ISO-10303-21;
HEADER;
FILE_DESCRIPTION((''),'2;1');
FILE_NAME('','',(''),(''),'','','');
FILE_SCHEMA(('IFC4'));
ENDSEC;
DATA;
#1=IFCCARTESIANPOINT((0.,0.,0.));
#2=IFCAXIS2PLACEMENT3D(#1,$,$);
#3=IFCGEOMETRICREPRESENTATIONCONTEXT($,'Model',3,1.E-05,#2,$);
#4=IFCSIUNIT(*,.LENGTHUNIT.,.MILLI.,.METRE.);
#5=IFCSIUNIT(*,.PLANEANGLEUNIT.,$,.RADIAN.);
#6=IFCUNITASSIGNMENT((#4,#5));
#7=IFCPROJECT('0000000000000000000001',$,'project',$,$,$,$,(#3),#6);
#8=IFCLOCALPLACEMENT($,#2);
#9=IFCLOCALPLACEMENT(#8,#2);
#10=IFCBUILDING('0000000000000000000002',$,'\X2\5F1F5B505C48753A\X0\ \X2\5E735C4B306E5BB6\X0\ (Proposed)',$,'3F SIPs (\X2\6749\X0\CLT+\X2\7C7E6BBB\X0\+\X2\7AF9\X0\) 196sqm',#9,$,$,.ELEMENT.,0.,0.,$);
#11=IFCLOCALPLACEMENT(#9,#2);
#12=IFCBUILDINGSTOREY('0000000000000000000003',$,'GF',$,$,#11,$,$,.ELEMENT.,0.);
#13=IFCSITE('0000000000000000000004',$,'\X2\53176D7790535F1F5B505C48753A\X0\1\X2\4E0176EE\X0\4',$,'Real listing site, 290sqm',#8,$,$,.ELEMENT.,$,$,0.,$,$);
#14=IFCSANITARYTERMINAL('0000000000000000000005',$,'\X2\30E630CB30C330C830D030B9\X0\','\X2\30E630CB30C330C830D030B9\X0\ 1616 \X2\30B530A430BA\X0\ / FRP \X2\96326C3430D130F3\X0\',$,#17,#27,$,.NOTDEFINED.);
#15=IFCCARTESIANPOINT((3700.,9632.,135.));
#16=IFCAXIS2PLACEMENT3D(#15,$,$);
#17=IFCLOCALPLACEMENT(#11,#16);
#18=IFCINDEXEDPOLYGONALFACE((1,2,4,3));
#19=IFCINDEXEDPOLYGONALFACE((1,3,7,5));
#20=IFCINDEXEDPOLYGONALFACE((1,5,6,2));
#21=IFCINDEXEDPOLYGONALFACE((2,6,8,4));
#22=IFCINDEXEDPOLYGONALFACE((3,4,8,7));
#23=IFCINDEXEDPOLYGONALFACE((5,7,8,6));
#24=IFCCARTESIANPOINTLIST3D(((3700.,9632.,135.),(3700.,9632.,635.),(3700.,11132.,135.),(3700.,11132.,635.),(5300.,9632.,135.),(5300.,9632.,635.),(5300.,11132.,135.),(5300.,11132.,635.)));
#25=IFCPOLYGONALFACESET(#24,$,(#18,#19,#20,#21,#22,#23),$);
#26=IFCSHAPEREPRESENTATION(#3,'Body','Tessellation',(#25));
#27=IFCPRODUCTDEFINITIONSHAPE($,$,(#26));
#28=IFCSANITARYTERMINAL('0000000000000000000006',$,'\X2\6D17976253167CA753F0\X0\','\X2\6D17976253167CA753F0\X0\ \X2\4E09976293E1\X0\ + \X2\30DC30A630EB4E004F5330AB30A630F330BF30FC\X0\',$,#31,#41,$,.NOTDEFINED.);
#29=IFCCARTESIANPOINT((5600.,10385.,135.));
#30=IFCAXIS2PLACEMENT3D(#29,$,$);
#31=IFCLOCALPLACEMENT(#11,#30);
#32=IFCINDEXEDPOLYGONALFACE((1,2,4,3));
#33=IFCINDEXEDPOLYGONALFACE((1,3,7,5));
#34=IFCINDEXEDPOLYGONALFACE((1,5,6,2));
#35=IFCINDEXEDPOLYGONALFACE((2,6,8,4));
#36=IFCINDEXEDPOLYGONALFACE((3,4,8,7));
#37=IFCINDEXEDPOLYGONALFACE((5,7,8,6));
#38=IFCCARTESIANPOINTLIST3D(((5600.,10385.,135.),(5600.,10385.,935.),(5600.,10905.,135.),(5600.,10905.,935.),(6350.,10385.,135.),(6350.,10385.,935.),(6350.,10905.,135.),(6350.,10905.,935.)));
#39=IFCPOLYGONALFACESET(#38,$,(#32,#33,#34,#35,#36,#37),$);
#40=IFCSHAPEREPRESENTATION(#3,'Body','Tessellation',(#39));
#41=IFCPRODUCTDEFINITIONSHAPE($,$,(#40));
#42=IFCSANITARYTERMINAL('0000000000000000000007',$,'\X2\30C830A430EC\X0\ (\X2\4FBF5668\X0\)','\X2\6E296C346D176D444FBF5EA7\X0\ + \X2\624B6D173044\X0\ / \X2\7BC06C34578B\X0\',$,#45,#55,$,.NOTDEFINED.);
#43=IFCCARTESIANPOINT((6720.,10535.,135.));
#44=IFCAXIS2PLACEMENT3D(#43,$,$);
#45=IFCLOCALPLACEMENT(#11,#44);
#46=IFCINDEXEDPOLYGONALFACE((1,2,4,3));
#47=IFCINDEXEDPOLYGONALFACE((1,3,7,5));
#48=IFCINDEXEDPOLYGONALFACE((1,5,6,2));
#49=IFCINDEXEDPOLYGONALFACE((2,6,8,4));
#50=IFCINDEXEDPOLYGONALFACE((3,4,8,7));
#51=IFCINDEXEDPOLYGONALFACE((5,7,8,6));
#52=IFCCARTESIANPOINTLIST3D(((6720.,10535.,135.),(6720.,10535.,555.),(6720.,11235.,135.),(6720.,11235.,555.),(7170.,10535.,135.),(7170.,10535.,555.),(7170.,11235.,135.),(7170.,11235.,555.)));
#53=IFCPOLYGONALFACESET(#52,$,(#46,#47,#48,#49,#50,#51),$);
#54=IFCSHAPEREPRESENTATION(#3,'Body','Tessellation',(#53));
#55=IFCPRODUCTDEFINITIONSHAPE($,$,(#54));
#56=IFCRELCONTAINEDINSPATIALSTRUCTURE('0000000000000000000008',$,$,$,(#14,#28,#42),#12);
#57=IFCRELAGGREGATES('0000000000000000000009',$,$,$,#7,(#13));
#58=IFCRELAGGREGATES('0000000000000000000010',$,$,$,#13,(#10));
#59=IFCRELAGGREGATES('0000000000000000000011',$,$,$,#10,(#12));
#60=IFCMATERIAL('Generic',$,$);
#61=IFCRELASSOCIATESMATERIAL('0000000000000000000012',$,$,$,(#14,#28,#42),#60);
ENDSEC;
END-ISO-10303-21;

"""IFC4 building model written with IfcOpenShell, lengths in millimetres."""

from ifc_helpers import new_model, si_unit, frame, frame_2d, origin, place, context, project, spatial, rectangle, extrude, material, element, save


model = new_model("IFC4")

# Units and contexts
model_context = context("Model", 3, precision=1e-05, world=origin())
ifc_project = project(units=[si_unit("LENGTHUNIT", "METRE", prefix="MILLI"), si_unit("PLANEANGLEUNIT", "RADIAN")], contexts=[model_context])

# Site, building, storey
site_placement = place(None, origin())
site = spatial("IfcSite", under=ifc_project, at=site_placement, Name="北海道弟子屈町1丁目4", ObjectType="Real listing site, 290sqm", CompositionType="ELEMENT", RefElevation=0.0)
building_placement = place(site_placement, origin())
building = spatial("IfcBuilding", under=site, at=building_placement, Name="弟子屈町 平屋の家 (Proposed)", ObjectType="3F SIPs (杉CLT+籾殻+竹) 196sqm", CompositionType="ELEMENT", ElevationOfRefHeight=0.0, ElevationOfTerrain=0.0)
storey_placement = place(building_placement, origin())
storey = spatial("IfcBuildingStorey", under=building, at=storey_placement, Name="GF", CompositionType="ELEMENT", Elevation=0.0)

# Shared definitions
ifc_material_1 = material(Name="Generic")

# Sanitary terminals
sanitary_terminal_1_placement = place(storey_placement, frame((3700.0, 9632.0, 135.0)))
element("IfcSanitaryTerminal", 1, at=sanitary_terminal_1_placement, inside=storey, material=ifc_material_1, Name="ユニットバス", Description="ユニットバス 1616 サイズ / FRP 防水パン", PredefinedType="NOTDEFINED", context=model_context, shape_type="SweptSolid", body=[
    extrude(rectangle(XDim=1600.0, YDim=1500.0, at=frame_2d((800.0, 750.0))), frame((3700.0, 9632.0, 135.0)), (0.0, 0.0, 1.0), 500.0),
])
sanitary_terminal_2_placement = place(storey_placement, frame((5600.0, 10385.0, 135.0)))
element("IfcSanitaryTerminal", 2, at=sanitary_terminal_2_placement, inside=storey, material=ifc_material_1, Name="洗面化粧台", Description="洗面化粧台 三面鏡 + ボウル一体カウンター", PredefinedType="NOTDEFINED", context=model_context, shape_type="SweptSolid", body=[
    extrude(rectangle(XDim=750.0, YDim=520.0, at=frame_2d((375.0, 260.0))), frame((5600.0, 10385.0, 135.0)), (0.0, 0.0, 1.0), 800.0),
])
sanitary_terminal_3_placement = place(storey_placement, frame((6720.0, 10535.0, 135.0)))
element("IfcSanitaryTerminal", 3, at=sanitary_terminal_3_placement, inside=storey, material=ifc_material_1, Name="トイレ (便器)", Description="温水洗浄便座 + 手洗い / 節水型", PredefinedType="NOTDEFINED", context=model_context, shape_type="SweptSolid", body=[
    extrude(rectangle(XDim=450.0, YDim=700.0, at=frame_2d((225.0, 350.0))), frame((6720.0, 10535.0, 135.0)), (0.0, 0.0, 1.0), 420.0),
])

save(model, "model.ifc")
